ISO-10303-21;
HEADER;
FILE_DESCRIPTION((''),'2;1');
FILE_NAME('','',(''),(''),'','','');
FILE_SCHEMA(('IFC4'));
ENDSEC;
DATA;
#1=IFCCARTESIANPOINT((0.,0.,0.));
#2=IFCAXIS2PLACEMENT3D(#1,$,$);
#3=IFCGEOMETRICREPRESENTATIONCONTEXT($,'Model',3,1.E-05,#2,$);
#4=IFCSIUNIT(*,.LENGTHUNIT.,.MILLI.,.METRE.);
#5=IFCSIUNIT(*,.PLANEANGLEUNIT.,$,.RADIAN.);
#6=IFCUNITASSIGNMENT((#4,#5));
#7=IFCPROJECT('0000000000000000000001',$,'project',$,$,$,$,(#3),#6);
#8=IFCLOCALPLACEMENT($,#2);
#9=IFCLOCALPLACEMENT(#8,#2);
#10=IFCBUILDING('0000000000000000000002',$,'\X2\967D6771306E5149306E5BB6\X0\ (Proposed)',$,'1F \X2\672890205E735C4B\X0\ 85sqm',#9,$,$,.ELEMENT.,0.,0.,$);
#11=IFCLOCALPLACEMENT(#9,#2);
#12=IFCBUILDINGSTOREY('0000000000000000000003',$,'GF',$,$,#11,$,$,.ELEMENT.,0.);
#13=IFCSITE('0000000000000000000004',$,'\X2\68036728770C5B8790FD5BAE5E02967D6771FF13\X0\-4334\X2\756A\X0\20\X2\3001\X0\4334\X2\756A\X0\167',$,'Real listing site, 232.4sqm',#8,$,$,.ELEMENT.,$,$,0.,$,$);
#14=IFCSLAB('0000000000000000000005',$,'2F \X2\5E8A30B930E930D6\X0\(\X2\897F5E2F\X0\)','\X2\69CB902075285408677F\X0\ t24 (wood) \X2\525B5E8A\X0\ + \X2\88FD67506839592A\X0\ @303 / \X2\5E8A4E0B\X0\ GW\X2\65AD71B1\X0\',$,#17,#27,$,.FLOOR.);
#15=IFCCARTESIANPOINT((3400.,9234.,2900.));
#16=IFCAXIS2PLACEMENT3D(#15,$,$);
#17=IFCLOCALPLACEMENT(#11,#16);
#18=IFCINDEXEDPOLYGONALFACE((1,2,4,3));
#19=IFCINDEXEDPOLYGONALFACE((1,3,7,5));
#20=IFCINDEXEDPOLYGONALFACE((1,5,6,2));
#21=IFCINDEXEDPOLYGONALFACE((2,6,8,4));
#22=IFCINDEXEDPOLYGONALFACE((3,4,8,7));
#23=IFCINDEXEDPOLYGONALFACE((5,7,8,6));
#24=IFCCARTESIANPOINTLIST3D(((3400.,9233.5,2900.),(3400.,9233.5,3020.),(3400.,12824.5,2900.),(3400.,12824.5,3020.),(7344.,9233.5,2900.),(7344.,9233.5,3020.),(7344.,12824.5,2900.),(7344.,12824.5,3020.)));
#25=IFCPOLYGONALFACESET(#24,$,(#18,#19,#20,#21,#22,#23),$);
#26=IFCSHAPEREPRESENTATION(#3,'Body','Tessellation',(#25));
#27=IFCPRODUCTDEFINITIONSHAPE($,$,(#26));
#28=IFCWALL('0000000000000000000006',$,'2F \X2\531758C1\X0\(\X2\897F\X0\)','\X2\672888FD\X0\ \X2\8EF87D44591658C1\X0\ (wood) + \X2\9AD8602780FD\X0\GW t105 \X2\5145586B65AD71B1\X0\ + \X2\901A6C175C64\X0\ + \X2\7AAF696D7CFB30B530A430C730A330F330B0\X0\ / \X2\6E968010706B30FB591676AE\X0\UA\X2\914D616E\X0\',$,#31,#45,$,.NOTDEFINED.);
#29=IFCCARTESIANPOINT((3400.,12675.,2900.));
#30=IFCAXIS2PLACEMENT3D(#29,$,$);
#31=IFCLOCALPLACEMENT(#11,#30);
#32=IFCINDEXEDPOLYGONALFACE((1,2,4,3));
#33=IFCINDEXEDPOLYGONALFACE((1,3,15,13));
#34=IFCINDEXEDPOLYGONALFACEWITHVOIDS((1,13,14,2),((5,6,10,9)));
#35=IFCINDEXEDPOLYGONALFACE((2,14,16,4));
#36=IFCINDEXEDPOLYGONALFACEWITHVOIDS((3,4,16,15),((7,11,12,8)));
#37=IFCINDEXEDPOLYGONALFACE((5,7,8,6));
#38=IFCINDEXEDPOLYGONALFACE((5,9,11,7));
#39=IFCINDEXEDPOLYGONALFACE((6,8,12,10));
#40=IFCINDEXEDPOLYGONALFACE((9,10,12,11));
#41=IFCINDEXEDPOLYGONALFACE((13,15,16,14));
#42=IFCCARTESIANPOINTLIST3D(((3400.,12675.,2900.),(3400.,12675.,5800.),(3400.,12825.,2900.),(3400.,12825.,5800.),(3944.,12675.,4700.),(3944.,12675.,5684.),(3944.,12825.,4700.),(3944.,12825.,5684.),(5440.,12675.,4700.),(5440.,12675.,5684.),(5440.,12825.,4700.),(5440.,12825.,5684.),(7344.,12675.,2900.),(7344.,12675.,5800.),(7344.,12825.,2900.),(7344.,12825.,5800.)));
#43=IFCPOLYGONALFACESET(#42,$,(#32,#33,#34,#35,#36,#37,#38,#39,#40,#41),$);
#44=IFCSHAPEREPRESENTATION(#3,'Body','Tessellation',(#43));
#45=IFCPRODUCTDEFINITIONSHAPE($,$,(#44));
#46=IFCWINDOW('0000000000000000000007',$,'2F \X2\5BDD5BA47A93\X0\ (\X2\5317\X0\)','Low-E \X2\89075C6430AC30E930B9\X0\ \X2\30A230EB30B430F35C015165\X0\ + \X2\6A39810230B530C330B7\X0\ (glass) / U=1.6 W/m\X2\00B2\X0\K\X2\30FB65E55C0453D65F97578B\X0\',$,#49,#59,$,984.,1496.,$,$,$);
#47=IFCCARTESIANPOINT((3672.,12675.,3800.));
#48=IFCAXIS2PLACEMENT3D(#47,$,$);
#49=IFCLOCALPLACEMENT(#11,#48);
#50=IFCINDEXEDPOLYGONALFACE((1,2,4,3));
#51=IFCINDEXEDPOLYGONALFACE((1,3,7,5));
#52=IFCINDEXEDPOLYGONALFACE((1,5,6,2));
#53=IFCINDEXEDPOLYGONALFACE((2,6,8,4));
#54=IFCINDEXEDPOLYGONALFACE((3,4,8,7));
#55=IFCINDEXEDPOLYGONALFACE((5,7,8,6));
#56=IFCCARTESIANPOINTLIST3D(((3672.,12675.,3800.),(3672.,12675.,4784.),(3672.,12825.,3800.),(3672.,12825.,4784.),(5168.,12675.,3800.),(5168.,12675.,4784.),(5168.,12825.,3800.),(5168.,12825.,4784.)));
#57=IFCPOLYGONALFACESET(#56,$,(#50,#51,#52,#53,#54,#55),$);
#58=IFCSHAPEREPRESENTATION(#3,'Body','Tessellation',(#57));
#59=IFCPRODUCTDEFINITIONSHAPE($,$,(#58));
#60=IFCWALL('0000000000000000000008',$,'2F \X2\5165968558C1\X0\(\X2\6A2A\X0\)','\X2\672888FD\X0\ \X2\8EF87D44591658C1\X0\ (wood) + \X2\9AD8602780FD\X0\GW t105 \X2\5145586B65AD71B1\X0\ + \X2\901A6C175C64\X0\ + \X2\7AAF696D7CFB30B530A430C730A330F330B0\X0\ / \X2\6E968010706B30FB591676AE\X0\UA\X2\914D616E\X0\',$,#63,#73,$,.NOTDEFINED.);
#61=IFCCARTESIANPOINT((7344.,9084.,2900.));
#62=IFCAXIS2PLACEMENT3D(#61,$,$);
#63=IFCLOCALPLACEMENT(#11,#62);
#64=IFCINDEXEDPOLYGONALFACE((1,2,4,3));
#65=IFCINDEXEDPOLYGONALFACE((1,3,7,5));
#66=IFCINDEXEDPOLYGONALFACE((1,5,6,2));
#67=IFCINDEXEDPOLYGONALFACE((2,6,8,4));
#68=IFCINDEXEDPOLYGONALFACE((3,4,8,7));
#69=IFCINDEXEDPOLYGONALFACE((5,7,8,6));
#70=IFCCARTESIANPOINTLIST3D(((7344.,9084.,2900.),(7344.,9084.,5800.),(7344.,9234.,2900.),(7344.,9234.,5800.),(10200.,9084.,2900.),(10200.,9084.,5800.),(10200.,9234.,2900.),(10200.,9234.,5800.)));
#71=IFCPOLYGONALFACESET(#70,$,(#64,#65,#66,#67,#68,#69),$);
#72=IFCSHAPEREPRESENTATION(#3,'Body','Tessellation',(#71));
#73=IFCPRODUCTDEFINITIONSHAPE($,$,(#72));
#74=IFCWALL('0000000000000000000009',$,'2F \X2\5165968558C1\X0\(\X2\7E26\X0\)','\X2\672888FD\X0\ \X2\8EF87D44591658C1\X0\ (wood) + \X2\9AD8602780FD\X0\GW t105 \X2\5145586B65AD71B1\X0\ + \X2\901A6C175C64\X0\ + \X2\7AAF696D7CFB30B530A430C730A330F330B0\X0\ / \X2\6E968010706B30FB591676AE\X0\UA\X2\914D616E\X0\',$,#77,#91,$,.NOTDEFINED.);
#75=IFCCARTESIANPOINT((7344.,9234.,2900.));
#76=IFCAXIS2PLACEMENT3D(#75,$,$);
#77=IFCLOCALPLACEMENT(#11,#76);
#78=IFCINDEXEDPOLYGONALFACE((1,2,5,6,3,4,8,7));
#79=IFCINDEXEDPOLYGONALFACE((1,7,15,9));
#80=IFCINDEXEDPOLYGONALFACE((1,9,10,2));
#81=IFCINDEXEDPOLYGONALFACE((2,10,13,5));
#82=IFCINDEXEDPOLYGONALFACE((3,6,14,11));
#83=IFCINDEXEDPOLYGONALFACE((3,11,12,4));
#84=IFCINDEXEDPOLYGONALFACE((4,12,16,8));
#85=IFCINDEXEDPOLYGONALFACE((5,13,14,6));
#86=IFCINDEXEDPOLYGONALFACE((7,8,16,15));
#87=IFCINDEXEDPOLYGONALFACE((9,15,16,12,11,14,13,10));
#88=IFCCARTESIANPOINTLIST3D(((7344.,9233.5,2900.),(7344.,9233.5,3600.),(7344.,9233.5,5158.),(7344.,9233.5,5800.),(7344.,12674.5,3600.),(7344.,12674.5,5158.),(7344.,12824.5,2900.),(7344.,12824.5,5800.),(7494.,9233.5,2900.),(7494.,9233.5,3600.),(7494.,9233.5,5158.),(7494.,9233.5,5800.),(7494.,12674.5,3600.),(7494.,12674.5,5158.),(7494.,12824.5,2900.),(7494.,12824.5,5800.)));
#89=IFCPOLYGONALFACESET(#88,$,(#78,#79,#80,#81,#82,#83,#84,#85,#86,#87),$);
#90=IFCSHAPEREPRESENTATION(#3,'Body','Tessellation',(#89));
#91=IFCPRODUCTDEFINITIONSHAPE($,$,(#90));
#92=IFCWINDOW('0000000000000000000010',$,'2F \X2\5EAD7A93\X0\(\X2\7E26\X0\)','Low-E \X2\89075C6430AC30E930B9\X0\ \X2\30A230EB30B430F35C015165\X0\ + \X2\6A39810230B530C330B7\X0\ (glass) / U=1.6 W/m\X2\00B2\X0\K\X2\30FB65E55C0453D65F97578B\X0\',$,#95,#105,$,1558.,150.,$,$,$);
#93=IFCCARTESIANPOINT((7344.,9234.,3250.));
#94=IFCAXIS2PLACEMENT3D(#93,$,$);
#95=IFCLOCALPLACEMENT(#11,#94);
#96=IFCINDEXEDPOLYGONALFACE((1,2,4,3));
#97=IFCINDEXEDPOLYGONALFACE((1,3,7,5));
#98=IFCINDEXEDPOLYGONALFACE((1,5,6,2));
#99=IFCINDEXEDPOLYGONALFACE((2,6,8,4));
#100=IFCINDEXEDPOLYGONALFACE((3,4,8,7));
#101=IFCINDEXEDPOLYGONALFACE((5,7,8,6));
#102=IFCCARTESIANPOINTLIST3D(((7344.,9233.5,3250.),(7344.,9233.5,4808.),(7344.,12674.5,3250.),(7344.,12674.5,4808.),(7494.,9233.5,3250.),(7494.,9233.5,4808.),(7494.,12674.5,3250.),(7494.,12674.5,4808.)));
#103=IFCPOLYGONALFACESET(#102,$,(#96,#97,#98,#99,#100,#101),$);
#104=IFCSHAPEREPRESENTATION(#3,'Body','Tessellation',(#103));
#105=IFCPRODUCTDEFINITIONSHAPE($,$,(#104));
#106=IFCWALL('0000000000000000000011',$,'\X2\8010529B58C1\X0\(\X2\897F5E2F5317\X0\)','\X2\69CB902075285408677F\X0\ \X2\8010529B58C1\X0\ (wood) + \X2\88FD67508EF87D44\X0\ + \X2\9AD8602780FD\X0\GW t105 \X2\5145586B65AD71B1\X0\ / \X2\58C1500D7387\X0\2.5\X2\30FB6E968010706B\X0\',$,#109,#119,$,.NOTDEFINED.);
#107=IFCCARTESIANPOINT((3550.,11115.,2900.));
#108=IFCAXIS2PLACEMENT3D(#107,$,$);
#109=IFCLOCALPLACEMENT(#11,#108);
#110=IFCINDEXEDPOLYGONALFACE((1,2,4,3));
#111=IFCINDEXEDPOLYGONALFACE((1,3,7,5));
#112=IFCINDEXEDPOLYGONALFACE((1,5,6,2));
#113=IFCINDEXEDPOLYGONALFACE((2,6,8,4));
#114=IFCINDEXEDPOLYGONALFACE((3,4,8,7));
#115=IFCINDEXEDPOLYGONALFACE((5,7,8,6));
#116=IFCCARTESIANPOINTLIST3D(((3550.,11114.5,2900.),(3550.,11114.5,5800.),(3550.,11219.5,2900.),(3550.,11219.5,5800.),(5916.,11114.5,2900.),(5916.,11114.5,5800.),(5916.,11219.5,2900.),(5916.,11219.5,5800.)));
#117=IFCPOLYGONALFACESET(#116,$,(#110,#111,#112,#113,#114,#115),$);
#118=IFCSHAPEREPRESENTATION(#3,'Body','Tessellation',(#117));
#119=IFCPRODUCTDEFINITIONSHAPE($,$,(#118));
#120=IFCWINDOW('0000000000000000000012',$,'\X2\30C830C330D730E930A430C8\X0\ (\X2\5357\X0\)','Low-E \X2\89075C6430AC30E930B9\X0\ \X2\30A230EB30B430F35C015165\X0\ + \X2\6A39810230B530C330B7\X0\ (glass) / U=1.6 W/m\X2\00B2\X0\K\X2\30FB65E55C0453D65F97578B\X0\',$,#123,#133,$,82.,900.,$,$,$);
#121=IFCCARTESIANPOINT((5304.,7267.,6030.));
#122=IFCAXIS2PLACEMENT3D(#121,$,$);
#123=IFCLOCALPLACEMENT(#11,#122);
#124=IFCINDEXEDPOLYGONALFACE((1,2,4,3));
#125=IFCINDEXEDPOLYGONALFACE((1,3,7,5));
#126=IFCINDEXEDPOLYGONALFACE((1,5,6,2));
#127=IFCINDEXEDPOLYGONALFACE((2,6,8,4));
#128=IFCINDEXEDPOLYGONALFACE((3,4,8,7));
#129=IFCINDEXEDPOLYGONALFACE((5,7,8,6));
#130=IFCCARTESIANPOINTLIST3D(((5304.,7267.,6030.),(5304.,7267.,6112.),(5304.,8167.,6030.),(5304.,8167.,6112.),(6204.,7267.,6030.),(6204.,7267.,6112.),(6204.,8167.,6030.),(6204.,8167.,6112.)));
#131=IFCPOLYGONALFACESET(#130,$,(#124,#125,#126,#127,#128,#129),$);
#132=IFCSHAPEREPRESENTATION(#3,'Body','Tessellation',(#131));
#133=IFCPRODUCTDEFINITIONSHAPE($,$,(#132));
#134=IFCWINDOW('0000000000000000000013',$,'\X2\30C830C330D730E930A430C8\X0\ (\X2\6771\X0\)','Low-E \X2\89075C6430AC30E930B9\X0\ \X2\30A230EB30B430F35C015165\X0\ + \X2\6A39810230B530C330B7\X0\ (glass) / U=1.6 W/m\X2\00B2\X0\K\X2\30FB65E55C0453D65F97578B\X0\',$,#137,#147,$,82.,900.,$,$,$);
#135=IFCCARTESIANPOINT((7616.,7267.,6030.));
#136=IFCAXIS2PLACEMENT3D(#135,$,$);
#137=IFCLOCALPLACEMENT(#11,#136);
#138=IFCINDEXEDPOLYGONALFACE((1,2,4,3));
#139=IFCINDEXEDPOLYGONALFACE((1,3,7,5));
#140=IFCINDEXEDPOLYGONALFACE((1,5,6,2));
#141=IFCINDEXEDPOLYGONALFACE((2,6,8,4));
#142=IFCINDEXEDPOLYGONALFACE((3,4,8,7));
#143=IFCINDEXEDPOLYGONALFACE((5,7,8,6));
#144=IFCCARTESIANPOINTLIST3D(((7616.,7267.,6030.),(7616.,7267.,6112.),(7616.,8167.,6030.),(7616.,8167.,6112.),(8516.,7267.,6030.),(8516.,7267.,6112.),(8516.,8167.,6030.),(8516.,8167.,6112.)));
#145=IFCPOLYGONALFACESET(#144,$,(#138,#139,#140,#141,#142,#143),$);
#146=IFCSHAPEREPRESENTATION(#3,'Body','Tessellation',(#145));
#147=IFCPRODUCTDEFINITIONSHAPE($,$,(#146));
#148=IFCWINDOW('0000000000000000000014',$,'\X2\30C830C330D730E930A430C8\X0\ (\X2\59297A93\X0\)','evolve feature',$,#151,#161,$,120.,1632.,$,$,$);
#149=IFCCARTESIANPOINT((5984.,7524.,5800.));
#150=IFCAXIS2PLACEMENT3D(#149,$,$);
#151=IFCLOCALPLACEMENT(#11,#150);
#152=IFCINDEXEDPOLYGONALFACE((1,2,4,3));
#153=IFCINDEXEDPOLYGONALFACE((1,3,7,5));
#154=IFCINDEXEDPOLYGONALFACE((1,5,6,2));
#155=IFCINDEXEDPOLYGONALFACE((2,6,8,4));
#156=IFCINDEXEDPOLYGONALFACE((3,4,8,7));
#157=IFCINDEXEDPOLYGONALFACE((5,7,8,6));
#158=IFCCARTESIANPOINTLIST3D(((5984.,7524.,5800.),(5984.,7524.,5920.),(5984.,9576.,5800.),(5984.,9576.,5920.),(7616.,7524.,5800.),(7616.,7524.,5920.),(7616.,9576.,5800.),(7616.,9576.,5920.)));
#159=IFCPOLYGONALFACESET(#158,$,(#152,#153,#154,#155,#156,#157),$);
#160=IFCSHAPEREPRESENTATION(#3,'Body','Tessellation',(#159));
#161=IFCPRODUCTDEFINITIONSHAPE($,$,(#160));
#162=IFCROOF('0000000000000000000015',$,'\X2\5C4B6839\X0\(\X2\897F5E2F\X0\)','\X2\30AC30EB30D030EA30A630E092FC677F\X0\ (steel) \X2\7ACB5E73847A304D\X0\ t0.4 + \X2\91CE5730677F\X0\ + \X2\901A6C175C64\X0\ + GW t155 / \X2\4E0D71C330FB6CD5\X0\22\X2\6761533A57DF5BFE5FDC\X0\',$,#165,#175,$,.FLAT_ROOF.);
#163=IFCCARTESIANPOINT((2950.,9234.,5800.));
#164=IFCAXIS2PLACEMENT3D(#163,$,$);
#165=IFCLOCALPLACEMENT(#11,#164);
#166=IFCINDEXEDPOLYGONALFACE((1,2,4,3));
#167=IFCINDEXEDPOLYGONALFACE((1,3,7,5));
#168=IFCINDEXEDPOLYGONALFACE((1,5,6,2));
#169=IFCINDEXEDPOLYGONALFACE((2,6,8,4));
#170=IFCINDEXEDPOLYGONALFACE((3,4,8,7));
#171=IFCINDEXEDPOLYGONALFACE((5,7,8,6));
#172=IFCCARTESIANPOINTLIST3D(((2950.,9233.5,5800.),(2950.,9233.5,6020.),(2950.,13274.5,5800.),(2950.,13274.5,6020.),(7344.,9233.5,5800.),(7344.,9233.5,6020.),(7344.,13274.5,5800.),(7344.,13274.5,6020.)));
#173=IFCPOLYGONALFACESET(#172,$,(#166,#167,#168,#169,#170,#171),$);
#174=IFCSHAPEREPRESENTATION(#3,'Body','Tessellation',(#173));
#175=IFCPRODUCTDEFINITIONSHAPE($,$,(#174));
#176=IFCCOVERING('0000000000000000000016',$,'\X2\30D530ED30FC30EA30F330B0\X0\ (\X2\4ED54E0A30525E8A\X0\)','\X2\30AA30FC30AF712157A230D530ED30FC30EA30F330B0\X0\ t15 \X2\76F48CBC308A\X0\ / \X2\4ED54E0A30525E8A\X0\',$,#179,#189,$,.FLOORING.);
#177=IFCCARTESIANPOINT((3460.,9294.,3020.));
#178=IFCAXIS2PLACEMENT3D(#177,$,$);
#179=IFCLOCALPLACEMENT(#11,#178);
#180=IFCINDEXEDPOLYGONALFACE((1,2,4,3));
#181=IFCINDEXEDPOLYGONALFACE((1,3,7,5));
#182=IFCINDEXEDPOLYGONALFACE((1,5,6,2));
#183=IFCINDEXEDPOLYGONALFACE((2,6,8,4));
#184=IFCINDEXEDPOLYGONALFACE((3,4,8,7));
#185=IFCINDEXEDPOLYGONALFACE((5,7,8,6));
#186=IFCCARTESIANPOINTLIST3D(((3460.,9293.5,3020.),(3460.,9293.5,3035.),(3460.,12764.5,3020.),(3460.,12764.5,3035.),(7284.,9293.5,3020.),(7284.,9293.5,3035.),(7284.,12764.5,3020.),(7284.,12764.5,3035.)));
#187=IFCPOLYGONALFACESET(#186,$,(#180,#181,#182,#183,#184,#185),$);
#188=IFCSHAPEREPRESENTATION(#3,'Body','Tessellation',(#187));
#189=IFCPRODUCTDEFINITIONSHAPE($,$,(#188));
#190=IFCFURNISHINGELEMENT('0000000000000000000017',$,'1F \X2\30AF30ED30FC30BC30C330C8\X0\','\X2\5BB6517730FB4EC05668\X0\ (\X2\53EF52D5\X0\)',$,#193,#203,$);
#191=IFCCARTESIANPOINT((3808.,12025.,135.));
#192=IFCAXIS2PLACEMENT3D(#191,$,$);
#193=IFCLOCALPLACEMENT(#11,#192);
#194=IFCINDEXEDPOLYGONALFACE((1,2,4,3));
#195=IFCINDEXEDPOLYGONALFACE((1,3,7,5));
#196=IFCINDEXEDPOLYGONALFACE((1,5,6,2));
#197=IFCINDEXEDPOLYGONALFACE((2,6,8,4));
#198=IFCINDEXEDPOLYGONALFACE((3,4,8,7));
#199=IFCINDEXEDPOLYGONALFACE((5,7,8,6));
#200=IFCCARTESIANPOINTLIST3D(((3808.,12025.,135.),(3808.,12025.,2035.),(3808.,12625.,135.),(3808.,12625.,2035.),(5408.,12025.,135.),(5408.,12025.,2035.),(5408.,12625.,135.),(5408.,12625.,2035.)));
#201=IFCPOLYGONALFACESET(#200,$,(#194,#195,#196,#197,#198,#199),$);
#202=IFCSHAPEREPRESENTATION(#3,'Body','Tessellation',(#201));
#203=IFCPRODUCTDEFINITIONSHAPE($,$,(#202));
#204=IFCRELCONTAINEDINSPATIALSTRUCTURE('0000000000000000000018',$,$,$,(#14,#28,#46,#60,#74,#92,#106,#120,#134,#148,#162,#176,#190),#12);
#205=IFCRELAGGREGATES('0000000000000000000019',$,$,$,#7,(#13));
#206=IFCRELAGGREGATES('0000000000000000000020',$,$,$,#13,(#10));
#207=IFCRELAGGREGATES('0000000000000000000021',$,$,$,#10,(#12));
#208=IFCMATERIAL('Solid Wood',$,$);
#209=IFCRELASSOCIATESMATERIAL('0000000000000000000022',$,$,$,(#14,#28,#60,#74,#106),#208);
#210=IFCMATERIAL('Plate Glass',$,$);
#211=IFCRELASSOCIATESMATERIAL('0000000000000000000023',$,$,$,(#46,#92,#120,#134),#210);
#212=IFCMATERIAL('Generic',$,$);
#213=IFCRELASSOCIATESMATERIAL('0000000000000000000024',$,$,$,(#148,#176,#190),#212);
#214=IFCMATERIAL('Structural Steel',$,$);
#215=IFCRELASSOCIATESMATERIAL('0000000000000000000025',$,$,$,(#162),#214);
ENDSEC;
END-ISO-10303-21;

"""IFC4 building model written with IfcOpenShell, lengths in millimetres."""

from ifc_helpers import new_model, si_unit, frame, frame_2d, origin, place, context, project, spatial, rectangle, extrude, material, element, fill, save


model = new_model("IFC4")

# Units and contexts
model_context = context("Model", 3, precision=1e-05, world=origin())
ifc_project = project(units=[si_unit("LENGTHUNIT", "METRE", prefix="MILLI"), si_unit("PLANEANGLEUNIT", "RADIAN")], contexts=[model_context])

# Site, building, storey
site_placement = place(None, origin())
site = spatial("IfcSite", under=ifc_project, at=site_placement, Name="栃木県宇都宮市陽東３-4334番20、4334番167", ObjectType="Real listing site, 232.4sqm", CompositionType="ELEMENT", RefElevation=0.0)
building_placement = place(site_placement, origin())
building = spatial("IfcBuilding", under=site, at=building_placement, Name="陽東の光の家 (Proposed)", ObjectType="1F 木造平屋 85sqm", CompositionType="ELEMENT", ElevationOfRefHeight=0.0, ElevationOfTerrain=0.0)
storey_placement = place(building_placement, origin())
storey = spatial("IfcBuildingStorey", under=building, at=storey_placement, Name="GF", CompositionType="ELEMENT", Elevation=0.0)

# Slab
ifc_material_1 = material(Name="Solid Wood")
slab_placement = place(storey_placement, frame((3400.0, 9234.0, 2900.0)))
element("IfcSlab", 1, at=slab_placement, inside=storey, material=ifc_material_1, Name="2F 床スラブ(西帯)", Description="構造用合板 t24 (wood) 剛床 + 製材根太 @303 / 床下 GW断熱", PredefinedType="FLOOR", context=model_context, shape_type="SweptSolid", body=[
    extrude(rectangle(XDim=3944.0, YDim=3591.0, at=frame_2d((1972.0, 1795.0))), frame((3400.0, 9234.0, 2900.0)), (0.0, 0.0, 1.0), 120.0),
])

# Wall, opening, window
wall_1_placement = place(storey_placement, frame((3400.0, 12675.0, 2900.0)))
wall_1 = element("IfcWall", 2, at=wall_1_placement, inside=storey, material=ifc_material_1, Name="2F 北壁(西)", Description="木製 軸組外壁 (wood) + 高性能GW t105 充填断熱 + 通気層 + 窯業系サイディング / 準耐火・外皮UA配慮", PredefinedType="NOTDEFINED", context=model_context, shape_type="SweptSolid", body=[
    extrude(rectangle(XDim=3944.0, YDim=150.0, at=frame_2d((1972.0, 75.0))), frame((3400.0, 12675.0, 2900.0)), (0.0, 0.0, 1.0), 2900.0),
])
opening_1_placement = place(storey_placement, frame((3672.0, 12675.0, 3800.0)))
opening_1 = element("IfcOpeningElement", 3, at=opening_1_placement, cuts=wall_1, PredefinedType="NOTDEFINED", context=model_context, shape_type="SweptSolid", body=[
    extrude(rectangle(XDim=1496.0, YDim=150.0, at=frame_2d((748.0, 75.0))), frame((3672.0, 12675.0, 3800.0)), (0.0, 0.0, 1.0), 984.0),
])
ifc_material_2 = material(Name="Plate Glass")
window_1_placement = place(storey_placement, frame((3672.0, 12675.0, 3800.0)))
window_1 = element("IfcWindow", 4, at=window_1_placement, inside=storey, material=ifc_material_2, Name="2F 寝室窓 (北)", Description="Low-E 複層ガラス アルゴン封入 + 樹脂サッシ (glass) / U=1.6 W/m²K・日射取得型", OverallHeight=984.0, OverallWidth=1496.0, context=model_context, shape_type="SweptSolid", body=[
    extrude(rectangle(XDim=1496.0, YDim=150.0, at=frame_2d((748.0, 75.0))), frame((3672.0, 12675.0, 3800.0)), (0.0, 0.0, 1.0), 984.0),
])
fill(opening_1, window_1)

# Wall
wall_2_placement = place(storey_placement, frame((7344.0, 9084.0, 2900.0)))
element("IfcWall", 5, at=wall_2_placement, inside=storey, material=ifc_material_1, Name="2F 入隅壁(横)", Description="木製 軸組外壁 (wood) + 高性能GW t105 充填断熱 + 通気層 + 窯業系サイディング / 準耐火・外皮UA配慮", PredefinedType="NOTDEFINED", context=model_context, shape_type="SweptSolid", body=[
    extrude(rectangle(XDim=2856.0, YDim=150.0, at=frame_2d((1428.0, 75.0))), frame((7344.0, 9084.0, 2900.0)), (0.0, 0.0, 1.0), 2900.0),
])

# Wall, opening, window
wall_3_placement = place(storey_placement, frame((7344.0, 9234.0, 2900.0)))
wall_3 = element("IfcWall", 6, at=wall_3_placement, inside=storey, material=ifc_material_1, Name="2F 入隅壁(縦)", Description="木製 軸組外壁 (wood) + 高性能GW t105 充填断熱 + 通気層 + 窯業系サイディング / 準耐火・外皮UA配慮", PredefinedType="NOTDEFINED", context=model_context, shape_type="SweptSolid", body=[
    extrude(rectangle(XDim=150.0, YDim=3591.0, at=frame_2d((75.0, 1795.0))), frame((7344.0, 9234.0, 2900.0)), (0.0, 0.0, 1.0), 2900.0),
])
opening_2_placement = place(storey_placement, frame((7344.0, 9234.0, 3250.0)))
opening_2 = element("IfcOpeningElement", 7, at=opening_2_placement, cuts=wall_3, PredefinedType="NOTDEFINED", context=model_context, shape_type="SweptSolid", body=[
    extrude(rectangle(XDim=150.0, YDim=3441.0, at=frame_2d((75.0, 1720.0))), frame((7344.0, 9234.0, 3250.0)), (0.0, 0.0, 1.0), 1558.0),
])
window_2_placement = place(storey_placement, frame((7344.0, 9234.0, 3250.0)))
window_2 = element("IfcWindow", 8, at=window_2_placement, inside=storey, material=ifc_material_2, Name="2F 庭窓(縦)", Description="Low-E 複層ガラス アルゴン封入 + 樹脂サッシ (glass) / U=1.6 W/m²K・日射取得型", OverallHeight=1558.0, OverallWidth=150.0, context=model_context, shape_type="SweptSolid", body=[
    extrude(rectangle(XDim=150.0, YDim=3441.0, at=frame_2d((75.0, 1720.0))), frame((7344.0, 9234.0, 3250.0)), (0.0, 0.0, 1.0), 1558.0),
])
fill(opening_2, window_2)

# Wall
wall_4_placement = place(storey_placement, frame((3550.0, 11115.0, 2900.0)))
element("IfcWall", 9, at=wall_4_placement, inside=storey, material=ifc_material_1, Name="耐力壁(西帯北)", Description="構造用合板 耐力壁 (wood) + 製材軸組 + 高性能GW t105 充填断熱 / 壁倍率2.5・準耐火", PredefinedType="NOTDEFINED", context=model_context, shape_type="SweptSolid", body=[
    extrude(rectangle(XDim=2366.0, YDim=105.0, at=frame_2d((1183.0, 52.0))), frame((3550.0, 11115.0, 2900.0)), (0.0, 0.0, 1.0), 2900.0),
])

# Windows
window_3_placement = place(storey_placement, frame((5304.0, 7267.0, 6030.0)))
element("IfcWindow", 10, at=window_3_placement, inside=storey, material=ifc_material_2, Name="トップライト (南)", Description="Low-E 複層ガラス アルゴン封入 + 樹脂サッシ (glass) / U=1.6 W/m²K・日射取得型", OverallHeight=82.0, OverallWidth=900.0, context=model_context, shape_type="SweptSolid", body=[
    extrude(rectangle(XDim=900.0, YDim=900.0, at=frame_2d((450.0, 450.0))), frame((5304.0, 7267.0, 6030.0)), (0.0, 0.0, 1.0), 82.0),
])
window_4_placement = place(storey_placement, frame((7616.0, 7267.0, 6030.0)))
element("IfcWindow", 11, at=window_4_placement, inside=storey, material=ifc_material_2, Name="トップライト (東)", Description="Low-E 複層ガラス アルゴン封入 + 樹脂サッシ (glass) / U=1.6 W/m²K・日射取得型", OverallHeight=82.0, OverallWidth=900.0, context=model_context, shape_type="SweptSolid", body=[
    extrude(rectangle(XDim=900.0, YDim=900.0, at=frame_2d((450.0, 450.0))), frame((7616.0, 7267.0, 6030.0)), (0.0, 0.0, 1.0), 82.0),
])
ifc_material_3 = material(Name="Generic")
window_5_placement = place(storey_placement, frame((5984.0, 7524.0, 5800.0)))
element("IfcWindow", 12, at=window_5_placement, inside=storey, material=ifc_material_3, Name="トップライト (天窓)", Description="evolve feature", OverallHeight=120.0, OverallWidth=1632.0, context=model_context, shape_type="SweptSolid", body=[
    extrude(rectangle(XDim=1632.0, YDim=2052.0, at=frame_2d((816.0, 1026.0))), frame((5984.0, 7524.0, 5800.0)), (0.0, 0.0, 1.0), 120.0),
])

# Roof
ifc_material_4 = material(Name="Structural Steel")
for number, where, name in (
    (13, (2950.0, 9234.0, 5800.0), "屋根(西帯)"),
):
    element("IfcRoof", number, at=place(storey_placement, frame(where)), inside=storey, material=ifc_material_4, Name=name, Description="ガルバリウム鋼板 (steel) 立平葺き t0.4 + 野地板 + 通気層 + GW t155 / 不燃・法22条区域対応", PredefinedType="FLAT_ROOF", context=model_context, shape_type="SweptSolid", body=[
        extrude(rectangle(XDim=4394.0, YDim=4041.0, at=frame_2d((2197.0, 2020.0))), frame((2950.0, 9234.0, 5800.0)), (0.0, 0.0, 1.0), 220.0),
    ])

# Covering
covering_placement = place(storey_placement, frame((3460.0, 9294.0, 3020.0)))
element("IfcCovering", 14, at=covering_placement, inside=storey, material=ifc_material_3, Name="フローリング (仕上げ床)", Description="オーク無垢フローリング t15 直貼り / 仕上げ床", PredefinedType="FLOORING", context=model_context, shape_type="SweptSolid", body=[
    extrude(rectangle(XDim=3824.0, YDim=3471.0, at=frame_2d((1912.0, 1735.0))), frame((3460.0, 9294.0, 3020.0)), (0.0, 0.0, 1.0), 15.0),
])

# Furnishing element
furnishing_1_placement = place(storey_placement, frame((3808.0, 12025.0, 135.0)))
element("IfcFurnishingElement", 15, at=furnishing_1_placement, inside=storey, material=ifc_material_3, Name="1F クローゼット", Description="家具・什器 (可動)", context=model_context, shape_type="SweptSolid", body=[
    extrude(rectangle(XDim=1600.0, YDim=600.0, at=frame_2d((800.0, 300.0))), frame((3808.0, 12025.0, 135.0)), (0.0, 0.0, 1.0), 1900.0),
])

save(model, "model.ifc")
